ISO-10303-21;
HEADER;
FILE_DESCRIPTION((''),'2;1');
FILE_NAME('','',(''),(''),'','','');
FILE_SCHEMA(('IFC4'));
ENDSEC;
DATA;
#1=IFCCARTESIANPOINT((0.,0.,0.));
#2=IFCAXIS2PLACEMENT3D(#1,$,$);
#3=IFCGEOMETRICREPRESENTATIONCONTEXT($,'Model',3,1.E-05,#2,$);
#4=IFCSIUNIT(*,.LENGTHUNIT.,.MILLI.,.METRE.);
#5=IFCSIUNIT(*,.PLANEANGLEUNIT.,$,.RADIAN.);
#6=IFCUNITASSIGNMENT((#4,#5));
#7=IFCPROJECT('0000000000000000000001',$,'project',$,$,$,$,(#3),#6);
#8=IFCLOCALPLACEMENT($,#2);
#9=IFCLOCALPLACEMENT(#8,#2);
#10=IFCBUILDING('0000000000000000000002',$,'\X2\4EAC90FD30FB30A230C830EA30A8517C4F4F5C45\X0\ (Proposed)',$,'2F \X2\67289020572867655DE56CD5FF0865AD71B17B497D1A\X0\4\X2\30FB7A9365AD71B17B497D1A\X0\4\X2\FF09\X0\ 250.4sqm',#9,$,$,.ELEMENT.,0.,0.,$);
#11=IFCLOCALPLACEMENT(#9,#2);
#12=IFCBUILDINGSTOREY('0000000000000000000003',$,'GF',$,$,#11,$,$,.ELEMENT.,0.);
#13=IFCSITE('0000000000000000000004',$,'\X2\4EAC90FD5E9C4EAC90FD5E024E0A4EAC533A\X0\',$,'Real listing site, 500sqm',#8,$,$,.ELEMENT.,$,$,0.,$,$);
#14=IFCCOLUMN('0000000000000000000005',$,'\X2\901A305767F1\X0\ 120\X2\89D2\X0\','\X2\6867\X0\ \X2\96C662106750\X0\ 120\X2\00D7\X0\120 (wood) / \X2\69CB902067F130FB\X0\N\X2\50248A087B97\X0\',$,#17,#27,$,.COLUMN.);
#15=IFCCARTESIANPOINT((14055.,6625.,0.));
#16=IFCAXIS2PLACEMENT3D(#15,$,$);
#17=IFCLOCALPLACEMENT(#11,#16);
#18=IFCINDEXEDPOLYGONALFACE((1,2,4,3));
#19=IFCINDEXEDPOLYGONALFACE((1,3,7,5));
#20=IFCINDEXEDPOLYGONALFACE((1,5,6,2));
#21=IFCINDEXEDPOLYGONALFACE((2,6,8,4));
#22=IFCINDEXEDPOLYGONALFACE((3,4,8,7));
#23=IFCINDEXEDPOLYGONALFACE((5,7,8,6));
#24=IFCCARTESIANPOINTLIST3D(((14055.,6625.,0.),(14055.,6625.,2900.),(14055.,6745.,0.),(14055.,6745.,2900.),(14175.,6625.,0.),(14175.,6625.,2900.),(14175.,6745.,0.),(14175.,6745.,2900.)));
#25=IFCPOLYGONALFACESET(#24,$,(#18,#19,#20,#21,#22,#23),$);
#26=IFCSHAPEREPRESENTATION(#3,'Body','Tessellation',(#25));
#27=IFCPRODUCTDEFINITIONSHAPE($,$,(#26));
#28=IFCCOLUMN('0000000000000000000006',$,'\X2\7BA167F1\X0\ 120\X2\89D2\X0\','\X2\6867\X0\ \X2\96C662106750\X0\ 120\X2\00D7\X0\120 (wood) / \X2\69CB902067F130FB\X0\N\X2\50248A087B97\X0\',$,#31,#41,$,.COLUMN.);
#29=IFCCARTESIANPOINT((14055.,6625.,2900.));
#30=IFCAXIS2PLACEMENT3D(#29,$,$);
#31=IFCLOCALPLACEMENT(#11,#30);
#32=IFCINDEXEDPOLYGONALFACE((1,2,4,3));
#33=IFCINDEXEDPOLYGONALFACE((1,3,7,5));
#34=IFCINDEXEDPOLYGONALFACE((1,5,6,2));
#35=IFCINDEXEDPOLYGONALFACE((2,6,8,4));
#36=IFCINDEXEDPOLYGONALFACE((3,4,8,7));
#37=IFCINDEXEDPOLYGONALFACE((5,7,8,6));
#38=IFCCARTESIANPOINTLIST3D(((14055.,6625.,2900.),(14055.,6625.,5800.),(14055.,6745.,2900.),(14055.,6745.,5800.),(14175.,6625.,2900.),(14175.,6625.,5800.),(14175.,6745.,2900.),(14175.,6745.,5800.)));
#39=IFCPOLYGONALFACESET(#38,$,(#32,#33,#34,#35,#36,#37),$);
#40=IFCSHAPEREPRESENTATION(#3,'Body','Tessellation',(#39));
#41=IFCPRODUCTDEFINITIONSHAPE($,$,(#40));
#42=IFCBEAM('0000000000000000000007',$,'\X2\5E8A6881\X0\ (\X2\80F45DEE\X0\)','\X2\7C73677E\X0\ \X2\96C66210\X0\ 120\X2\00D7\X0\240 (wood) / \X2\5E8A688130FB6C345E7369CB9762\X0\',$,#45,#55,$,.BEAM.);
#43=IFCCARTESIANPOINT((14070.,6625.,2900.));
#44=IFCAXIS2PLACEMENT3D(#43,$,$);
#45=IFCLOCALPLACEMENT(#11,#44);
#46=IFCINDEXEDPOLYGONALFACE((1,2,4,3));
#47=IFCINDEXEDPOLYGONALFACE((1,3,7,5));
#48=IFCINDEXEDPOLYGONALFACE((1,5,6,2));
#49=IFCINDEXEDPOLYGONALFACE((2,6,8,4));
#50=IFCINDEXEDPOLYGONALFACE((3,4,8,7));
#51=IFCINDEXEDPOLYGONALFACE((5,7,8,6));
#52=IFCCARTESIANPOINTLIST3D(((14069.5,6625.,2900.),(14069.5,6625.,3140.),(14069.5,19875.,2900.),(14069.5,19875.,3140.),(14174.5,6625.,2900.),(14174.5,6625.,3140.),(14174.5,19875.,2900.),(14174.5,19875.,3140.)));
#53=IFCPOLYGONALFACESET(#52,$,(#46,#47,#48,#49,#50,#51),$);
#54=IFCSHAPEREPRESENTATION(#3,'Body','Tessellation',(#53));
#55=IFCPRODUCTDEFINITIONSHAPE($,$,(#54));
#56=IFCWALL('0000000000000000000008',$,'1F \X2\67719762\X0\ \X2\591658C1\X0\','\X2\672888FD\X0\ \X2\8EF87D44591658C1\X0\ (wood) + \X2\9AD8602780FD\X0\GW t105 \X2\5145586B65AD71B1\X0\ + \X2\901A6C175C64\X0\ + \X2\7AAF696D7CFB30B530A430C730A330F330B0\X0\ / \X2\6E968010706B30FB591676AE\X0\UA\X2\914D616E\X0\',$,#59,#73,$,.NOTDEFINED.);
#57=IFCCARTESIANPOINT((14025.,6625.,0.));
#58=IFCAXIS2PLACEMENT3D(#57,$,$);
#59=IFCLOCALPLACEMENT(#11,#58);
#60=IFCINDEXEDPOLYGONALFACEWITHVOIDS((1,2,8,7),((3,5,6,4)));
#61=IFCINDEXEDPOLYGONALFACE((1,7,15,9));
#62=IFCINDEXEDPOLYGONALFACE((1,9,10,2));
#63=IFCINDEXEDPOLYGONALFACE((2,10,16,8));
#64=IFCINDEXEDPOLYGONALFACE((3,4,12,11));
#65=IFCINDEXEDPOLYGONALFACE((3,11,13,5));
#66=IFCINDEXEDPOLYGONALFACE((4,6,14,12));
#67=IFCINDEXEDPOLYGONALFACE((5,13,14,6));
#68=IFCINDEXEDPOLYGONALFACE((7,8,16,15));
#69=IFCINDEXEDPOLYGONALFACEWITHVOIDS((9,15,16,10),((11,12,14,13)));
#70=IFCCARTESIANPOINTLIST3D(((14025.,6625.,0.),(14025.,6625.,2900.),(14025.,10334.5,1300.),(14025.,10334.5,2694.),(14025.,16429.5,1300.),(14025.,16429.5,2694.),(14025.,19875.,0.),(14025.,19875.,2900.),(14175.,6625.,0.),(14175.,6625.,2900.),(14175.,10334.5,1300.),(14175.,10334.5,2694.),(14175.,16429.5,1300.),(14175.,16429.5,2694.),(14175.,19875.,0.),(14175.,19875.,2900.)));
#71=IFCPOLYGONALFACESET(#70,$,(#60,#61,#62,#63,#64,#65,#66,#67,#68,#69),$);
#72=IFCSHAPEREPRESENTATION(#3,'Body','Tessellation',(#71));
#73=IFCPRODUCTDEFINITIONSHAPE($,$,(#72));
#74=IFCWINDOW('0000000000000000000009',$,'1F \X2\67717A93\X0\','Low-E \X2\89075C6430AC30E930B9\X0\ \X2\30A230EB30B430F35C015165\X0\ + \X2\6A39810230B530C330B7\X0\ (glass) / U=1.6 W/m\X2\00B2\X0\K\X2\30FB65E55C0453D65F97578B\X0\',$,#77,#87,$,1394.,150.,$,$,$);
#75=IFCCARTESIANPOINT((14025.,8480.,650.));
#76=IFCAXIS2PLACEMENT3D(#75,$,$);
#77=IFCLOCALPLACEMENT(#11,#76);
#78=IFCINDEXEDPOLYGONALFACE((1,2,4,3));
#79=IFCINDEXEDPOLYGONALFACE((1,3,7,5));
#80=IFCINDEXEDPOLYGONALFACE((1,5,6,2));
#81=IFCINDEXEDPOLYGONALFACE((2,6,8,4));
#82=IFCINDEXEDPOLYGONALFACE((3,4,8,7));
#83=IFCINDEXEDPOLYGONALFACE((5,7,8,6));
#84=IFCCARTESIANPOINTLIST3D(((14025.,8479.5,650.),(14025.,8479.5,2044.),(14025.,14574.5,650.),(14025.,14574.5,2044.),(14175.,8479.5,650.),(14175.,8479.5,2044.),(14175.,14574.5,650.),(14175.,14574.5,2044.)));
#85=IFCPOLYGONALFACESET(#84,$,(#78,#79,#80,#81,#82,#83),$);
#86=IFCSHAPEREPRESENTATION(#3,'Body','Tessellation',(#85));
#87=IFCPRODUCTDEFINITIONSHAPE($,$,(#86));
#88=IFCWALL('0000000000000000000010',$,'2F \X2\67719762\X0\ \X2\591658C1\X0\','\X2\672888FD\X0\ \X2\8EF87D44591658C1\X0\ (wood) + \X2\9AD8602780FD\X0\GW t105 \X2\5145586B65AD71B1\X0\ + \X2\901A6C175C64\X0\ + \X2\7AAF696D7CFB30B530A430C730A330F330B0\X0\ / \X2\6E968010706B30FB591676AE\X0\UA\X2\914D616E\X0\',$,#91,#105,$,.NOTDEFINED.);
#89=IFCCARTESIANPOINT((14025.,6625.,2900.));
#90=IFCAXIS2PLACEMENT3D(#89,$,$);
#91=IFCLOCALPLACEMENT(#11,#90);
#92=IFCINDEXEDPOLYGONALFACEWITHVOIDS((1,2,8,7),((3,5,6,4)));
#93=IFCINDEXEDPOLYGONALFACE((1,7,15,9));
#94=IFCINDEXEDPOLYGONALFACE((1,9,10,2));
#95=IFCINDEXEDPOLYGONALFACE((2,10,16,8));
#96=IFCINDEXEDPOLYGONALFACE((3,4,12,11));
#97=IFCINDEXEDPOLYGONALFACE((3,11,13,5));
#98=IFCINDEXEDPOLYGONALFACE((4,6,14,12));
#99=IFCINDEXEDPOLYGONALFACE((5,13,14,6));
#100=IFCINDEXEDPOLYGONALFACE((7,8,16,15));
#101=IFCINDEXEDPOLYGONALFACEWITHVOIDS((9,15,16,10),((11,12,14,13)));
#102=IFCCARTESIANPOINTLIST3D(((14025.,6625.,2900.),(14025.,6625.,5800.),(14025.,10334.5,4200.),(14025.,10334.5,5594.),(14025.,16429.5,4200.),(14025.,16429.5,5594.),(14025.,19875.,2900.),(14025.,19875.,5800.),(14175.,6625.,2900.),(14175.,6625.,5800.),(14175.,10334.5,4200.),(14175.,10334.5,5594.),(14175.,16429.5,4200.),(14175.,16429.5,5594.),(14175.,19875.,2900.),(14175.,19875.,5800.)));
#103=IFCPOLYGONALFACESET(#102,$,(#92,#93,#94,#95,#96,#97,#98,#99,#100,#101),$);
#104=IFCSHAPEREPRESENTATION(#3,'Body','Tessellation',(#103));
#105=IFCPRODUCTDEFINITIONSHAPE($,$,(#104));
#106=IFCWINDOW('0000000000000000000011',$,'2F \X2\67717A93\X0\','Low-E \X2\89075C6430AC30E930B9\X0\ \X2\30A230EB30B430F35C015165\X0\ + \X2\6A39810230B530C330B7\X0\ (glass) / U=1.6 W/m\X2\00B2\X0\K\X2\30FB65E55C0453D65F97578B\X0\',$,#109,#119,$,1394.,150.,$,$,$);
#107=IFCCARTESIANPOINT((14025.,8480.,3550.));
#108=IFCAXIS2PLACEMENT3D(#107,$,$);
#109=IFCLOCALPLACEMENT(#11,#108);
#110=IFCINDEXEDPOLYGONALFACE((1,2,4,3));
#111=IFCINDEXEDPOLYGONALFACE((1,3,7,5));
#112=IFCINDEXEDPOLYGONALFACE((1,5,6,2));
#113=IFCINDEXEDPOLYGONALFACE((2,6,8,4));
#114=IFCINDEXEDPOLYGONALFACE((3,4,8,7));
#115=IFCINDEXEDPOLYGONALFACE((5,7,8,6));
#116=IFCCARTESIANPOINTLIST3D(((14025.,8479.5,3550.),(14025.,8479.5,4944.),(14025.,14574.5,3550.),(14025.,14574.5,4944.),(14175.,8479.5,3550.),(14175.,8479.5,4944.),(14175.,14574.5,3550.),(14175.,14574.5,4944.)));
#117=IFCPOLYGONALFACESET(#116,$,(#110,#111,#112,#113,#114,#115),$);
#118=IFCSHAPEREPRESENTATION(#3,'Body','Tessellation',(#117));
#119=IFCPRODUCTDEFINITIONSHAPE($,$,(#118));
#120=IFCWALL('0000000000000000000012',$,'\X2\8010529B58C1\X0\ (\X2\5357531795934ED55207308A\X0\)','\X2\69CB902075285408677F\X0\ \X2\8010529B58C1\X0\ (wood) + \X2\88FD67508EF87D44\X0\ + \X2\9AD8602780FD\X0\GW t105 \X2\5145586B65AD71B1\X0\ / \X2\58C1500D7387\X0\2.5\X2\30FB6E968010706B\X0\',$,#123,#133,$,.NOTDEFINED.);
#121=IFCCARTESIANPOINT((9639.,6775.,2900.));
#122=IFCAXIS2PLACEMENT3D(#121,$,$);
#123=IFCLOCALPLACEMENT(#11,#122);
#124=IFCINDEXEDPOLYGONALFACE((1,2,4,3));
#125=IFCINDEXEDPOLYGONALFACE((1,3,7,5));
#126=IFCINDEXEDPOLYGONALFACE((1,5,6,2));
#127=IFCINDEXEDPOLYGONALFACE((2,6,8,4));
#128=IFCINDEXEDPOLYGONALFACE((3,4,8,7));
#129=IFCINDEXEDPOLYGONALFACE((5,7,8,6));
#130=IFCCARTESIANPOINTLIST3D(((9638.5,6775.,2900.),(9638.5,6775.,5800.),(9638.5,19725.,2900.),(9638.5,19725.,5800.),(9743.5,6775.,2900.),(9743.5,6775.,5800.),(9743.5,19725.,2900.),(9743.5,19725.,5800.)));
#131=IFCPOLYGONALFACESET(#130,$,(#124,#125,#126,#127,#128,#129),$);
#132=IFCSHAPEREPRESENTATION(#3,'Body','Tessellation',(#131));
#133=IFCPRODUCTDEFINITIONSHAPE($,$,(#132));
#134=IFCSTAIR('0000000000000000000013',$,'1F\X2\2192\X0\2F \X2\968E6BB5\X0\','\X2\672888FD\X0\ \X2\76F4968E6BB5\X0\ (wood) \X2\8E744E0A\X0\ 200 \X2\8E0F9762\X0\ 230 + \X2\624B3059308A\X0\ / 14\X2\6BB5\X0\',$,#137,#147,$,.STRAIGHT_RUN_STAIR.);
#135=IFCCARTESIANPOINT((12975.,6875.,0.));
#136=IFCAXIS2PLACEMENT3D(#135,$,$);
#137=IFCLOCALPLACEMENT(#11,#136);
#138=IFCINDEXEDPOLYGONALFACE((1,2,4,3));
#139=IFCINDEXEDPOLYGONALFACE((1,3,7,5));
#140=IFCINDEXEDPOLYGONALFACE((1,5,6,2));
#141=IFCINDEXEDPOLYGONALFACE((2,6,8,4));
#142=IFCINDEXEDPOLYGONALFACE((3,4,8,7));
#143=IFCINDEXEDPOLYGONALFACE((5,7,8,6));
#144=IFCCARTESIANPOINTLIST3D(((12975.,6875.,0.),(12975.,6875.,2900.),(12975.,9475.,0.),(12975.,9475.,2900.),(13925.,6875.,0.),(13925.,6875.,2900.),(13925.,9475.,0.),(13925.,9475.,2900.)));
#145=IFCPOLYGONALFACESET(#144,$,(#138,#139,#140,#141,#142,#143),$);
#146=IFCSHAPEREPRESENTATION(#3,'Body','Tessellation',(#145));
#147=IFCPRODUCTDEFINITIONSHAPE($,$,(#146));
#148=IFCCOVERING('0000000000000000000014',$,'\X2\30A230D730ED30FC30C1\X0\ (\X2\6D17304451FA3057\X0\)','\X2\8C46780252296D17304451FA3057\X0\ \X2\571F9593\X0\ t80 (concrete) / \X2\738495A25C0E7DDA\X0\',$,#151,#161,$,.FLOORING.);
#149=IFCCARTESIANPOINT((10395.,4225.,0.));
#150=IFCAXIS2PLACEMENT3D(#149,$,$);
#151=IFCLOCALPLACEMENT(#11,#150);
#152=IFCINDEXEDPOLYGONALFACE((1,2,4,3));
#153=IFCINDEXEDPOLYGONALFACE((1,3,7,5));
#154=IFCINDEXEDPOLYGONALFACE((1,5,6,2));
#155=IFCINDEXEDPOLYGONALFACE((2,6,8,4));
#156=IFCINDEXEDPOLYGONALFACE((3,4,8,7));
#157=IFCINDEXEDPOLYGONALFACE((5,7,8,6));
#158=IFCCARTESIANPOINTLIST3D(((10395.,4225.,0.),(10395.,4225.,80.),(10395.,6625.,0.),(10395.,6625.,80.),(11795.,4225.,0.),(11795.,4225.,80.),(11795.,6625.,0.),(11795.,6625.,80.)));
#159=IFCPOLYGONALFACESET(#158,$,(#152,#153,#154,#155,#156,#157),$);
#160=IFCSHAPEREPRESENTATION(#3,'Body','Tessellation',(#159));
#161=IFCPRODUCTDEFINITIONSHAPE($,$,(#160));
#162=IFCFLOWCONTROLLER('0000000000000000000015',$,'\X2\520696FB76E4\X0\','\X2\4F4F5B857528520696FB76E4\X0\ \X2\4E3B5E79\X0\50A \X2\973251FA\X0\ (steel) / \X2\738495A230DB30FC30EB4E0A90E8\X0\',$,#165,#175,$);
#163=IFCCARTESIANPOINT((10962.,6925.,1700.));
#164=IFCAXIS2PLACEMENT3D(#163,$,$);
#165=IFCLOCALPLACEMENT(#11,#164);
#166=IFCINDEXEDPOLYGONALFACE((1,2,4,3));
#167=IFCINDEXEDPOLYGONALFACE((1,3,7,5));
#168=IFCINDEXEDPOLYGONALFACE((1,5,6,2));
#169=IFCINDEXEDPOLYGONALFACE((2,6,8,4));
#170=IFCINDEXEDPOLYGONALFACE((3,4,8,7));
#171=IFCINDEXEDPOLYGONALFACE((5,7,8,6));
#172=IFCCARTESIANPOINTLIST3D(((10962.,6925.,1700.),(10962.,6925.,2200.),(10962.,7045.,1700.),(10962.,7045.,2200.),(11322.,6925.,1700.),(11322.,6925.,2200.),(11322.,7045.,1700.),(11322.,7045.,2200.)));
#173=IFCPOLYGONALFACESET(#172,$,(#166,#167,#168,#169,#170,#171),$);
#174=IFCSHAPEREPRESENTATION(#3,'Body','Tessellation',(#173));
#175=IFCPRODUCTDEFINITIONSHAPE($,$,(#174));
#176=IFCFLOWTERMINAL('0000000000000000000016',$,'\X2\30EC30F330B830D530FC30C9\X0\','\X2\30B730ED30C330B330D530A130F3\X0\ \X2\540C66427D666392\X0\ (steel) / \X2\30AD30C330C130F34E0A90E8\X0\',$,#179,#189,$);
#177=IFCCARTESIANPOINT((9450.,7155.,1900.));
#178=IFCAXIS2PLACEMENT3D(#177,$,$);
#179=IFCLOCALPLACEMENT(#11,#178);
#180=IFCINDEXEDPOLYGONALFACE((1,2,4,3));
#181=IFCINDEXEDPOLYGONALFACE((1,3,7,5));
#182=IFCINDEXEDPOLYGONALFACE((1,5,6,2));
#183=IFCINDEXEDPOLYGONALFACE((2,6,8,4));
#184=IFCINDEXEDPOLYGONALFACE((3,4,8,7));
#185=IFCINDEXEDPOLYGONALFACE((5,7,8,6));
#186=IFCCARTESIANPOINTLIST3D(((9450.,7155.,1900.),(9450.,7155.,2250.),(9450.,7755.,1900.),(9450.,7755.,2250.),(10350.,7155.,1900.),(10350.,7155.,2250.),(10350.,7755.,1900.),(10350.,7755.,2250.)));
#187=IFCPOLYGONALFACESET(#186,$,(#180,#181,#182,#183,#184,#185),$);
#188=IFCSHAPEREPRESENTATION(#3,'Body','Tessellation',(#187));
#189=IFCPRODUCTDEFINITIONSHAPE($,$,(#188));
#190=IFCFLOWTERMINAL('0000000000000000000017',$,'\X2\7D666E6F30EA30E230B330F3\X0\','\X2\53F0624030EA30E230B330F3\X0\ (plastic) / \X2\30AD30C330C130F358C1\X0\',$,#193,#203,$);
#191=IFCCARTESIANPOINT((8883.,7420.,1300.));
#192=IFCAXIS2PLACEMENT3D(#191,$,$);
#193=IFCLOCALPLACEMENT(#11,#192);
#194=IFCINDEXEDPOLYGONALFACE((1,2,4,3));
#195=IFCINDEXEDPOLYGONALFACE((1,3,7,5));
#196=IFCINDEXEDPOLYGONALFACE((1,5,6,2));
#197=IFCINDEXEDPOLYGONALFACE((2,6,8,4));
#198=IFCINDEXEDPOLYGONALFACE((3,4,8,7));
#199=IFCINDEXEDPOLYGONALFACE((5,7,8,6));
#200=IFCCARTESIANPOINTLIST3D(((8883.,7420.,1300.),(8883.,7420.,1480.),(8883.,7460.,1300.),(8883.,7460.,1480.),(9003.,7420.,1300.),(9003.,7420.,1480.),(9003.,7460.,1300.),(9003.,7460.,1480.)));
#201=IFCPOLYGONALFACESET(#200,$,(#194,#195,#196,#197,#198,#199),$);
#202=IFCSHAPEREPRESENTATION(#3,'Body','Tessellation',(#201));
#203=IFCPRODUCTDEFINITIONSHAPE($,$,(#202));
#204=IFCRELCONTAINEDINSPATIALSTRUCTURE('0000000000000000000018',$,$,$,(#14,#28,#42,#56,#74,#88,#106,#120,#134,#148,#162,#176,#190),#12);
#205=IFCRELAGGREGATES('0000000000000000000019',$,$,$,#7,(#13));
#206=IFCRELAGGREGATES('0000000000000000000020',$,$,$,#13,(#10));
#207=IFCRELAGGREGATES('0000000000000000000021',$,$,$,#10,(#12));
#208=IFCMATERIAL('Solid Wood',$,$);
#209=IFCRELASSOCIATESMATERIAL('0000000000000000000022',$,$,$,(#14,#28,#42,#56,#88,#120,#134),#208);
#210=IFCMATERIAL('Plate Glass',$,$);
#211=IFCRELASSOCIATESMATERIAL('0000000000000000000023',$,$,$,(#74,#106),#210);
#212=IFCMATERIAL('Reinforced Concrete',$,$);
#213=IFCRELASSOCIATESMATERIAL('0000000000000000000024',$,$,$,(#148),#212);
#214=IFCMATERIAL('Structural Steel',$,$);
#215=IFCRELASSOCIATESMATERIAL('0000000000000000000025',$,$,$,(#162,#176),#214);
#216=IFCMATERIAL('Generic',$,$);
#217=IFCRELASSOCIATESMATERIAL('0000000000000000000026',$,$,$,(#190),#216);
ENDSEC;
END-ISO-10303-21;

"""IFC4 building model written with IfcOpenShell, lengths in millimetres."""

from ifc_helpers import new_model, si_unit, frame, frame_2d, origin, place, context, project, spatial, rectangle, extrude, material, element, fill, save


model = new_model("IFC4")

# Units and contexts
model_context = context("Model", 3, precision=1e-05, world=origin())
ifc_project = project(units=[si_unit("LENGTHUNIT", "METRE", prefix="MILLI"), si_unit("PLANEANGLEUNIT", "RADIAN")], contexts=[model_context])

# Site, building, storey
site_placement = place(None, origin())
site = spatial("IfcSite", under=ifc_project, at=site_placement, Name="京都府京都市上京区", ObjectType="Real listing site, 500sqm", CompositionType="ELEMENT", RefElevation=0.0)
building_placement = place(site_placement, origin())
building = spatial("IfcBuilding", under=site, at=building_placement, Name="京都・アトリエ兼住居 (Proposed)", ObjectType="2F 木造在来工法（断熱等級4・窓断熱等級4） 250.4sqm", CompositionType="ELEMENT", ElevationOfRefHeight=0.0, ElevationOfTerrain=0.0)
storey_placement = place(building_placement, origin())
storey = spatial("IfcBuildingStorey", under=building, at=storey_placement, Name="GF", CompositionType="ELEMENT", Elevation=0.0)

# Columns
ifc_material_1 = material(Name="Solid Wood")
column_1_placement = place(storey_placement, frame((14055.0, 6625.0, 0.0)))
element("IfcColumn", 1, at=column_1_placement, inside=storey, material=ifc_material_1, Name="通し柱 120角", Description="桧 集成材 120×120 (wood) / 構造柱・N値計算", PredefinedType="COLUMN", context=model_context, shape_type="SweptSolid", body=[
    extrude(rectangle(XDim=120.0, YDim=120.0, at=frame_2d((60.0, 60.0))), frame((14055.0, 6625.0, 0.0)), (0.0, 0.0, 1.0), 2900.0),
])
column_2_placement = place(storey_placement, frame((14055.0, 6625.0, 2900.0)))
element("IfcColumn", 2, at=column_2_placement, inside=storey, material=ifc_material_1, Name="管柱 120角", Description="桧 集成材 120×120 (wood) / 構造柱・N値計算", PredefinedType="COLUMN", context=model_context, shape_type="SweptSolid", body=[
    extrude(rectangle(XDim=120.0, YDim=120.0, at=frame_2d((60.0, 60.0))), frame((14055.0, 6625.0, 2900.0)), (0.0, 0.0, 1.0), 2900.0),
])

# Beam
beam_1_placement = place(storey_placement, frame((14070.0, 6625.0, 2900.0)))
element("IfcBeam", 3, at=beam_1_placement, inside=storey, material=ifc_material_1, Name="床梁 (胴差)", Description="米松 集成 120×240 (wood) / 床梁・水平構面", PredefinedType="BEAM", context=model_context, shape_type="SweptSolid", body=[
    extrude(rectangle(XDim=105.0, YDim=13250.0, at=frame_2d((52.0, 6625.0))), frame((14070.0, 6625.0, 2900.0)), (0.0, 0.0, 1.0), 240.0),
])

# Wall, opening, window
wall_1_placement = place(storey_placement, frame((14025.0, 6625.0, 0.0)))
wall_1 = element("IfcWall", 4, at=wall_1_placement, inside=storey, material=ifc_material_1, Name="1F 東面 外壁", Description="木製 軸組外壁 (wood) + 高性能GW t105 充填断熱 + 通気層 + 窯業系サイディング / 準耐火・外皮UA配慮", PredefinedType="NOTDEFINED", context=model_context, shape_type="SweptSolid", body=[
    extrude(rectangle(XDim=150.0, YDim=13250.0, at=frame_2d((75.0, 6625.0))), frame((14025.0, 6625.0, 0.0)), (0.0, 0.0, 1.0), 2900.0),
])
opening_1_placement = place(storey_placement, frame((14025.0, 8480.0, 650.0)))
opening_1 = element("IfcOpeningElement", 5, at=opening_1_placement, cuts=wall_1, PredefinedType="NOTDEFINED", context=model_context, shape_type="SweptSolid", body=[
    extrude(rectangle(XDim=150.0, YDim=6095.0, at=frame_2d((75.0, 3047.0))), frame((14025.0, 8480.0, 650.0)), (0.0, 0.0, 1.0), 1394.0),
])
ifc_material_2 = material(Name="Plate Glass")
window_1_placement = place(storey_placement, frame((14025.0, 8480.0, 650.0)))
window_1 = element("IfcWindow", 6, at=window_1_placement, inside=storey, material=ifc_material_2, Name="1F 東窓", Description="Low-E 複層ガラス アルゴン封入 + 樹脂サッシ (glass) / U=1.6 W/m²K・日射取得型", OverallHeight=1394.0, OverallWidth=150.0, context=model_context, shape_type="SweptSolid", body=[
    extrude(rectangle(XDim=150.0, YDim=6095.0, at=frame_2d((75.0, 3047.0))), frame((14025.0, 8480.0, 650.0)), (0.0, 0.0, 1.0), 1394.0),
])
fill(opening_1, window_1)

# Wall, opening, window
wall_2_placement = place(storey_placement, frame((14025.0, 6625.0, 2900.0)))
wall_2 = element("IfcWall", 7, at=wall_2_placement, inside=storey, material=ifc_material_1, Name="2F 東面 外壁", Description="木製 軸組外壁 (wood) + 高性能GW t105 充填断熱 + 通気層 + 窯業系サイディング / 準耐火・外皮UA配慮", PredefinedType="NOTDEFINED", context=model_context, shape_type="SweptSolid", body=[
    extrude(rectangle(XDim=150.0, YDim=13250.0, at=frame_2d((75.0, 6625.0))), frame((14025.0, 6625.0, 2900.0)), (0.0, 0.0, 1.0), 2900.0),
])
opening_2_placement = place(storey_placement, frame((14025.0, 8480.0, 3550.0)))
opening_2 = element("IfcOpeningElement", 8, at=opening_2_placement, cuts=wall_2, PredefinedType="NOTDEFINED", context=model_context, shape_type="SweptSolid", body=[
    extrude(rectangle(XDim=150.0, YDim=6095.0, at=frame_2d((75.0, 3047.0))), frame((14025.0, 8480.0, 3550.0)), (0.0, 0.0, 1.0), 1394.0),
])
window_2_placement = place(storey_placement, frame((14025.0, 8480.0, 3550.0)))
window_2 = element("IfcWindow", 9, at=window_2_placement, inside=storey, material=ifc_material_2, Name="2F 東窓", Description="Low-E 複層ガラス アルゴン封入 + 樹脂サッシ (glass) / U=1.6 W/m²K・日射取得型", OverallHeight=1394.0, OverallWidth=150.0, context=model_context, shape_type="SweptSolid", body=[
    extrude(rectangle(XDim=150.0, YDim=6095.0, at=frame_2d((75.0, 3047.0))), frame((14025.0, 8480.0, 3550.0)), (0.0, 0.0, 1.0), 1394.0),
])
fill(opening_2, window_2)

# Wall
wall_3_placement = place(storey_placement, frame((9639.0, 6775.0, 2900.0)))
element("IfcWall", 10, at=wall_3_placement, inside=storey, material=ifc_material_1, Name="耐力壁 (南北間仕切り)", Description="構造用合板 耐力壁 (wood) + 製材軸組 + 高性能GW t105 充填断熱 / 壁倍率2.5・準耐火", PredefinedType="NOTDEFINED", context=model_context, shape_type="SweptSolid", body=[
    extrude(rectangle(XDim=105.0, YDim=12950.0, at=frame_2d((52.0, 6475.0))), frame((9639.0, 6775.0, 2900.0)), (0.0, 0.0, 1.0), 2900.0),
])

# Stair
stair_placement = place(storey_placement, frame((12975.0, 6875.0, 0.0)))
element("IfcStair", 11, at=stair_placement, inside=storey, material=ifc_material_1, Name="1F→2F 階段", Description="木製 直階段 (wood) 蹴上 200 踏面 230 + 手すり / 14段", PredefinedType="STRAIGHT_RUN_STAIR", context=model_context, shape_type="SweptSolid", body=[
    extrude(rectangle(XDim=950.0, YDim=2600.0, at=frame_2d((475.0, 1300.0))), frame((12975.0, 6875.0, 0.0)), (0.0, 0.0, 1.0), 2900.0),
])

# Covering
ifc_material_3 = material(Name="Reinforced Concrete")
covering_placement = place(storey_placement, frame((10395.0, 4225.0, 0.0)))
element("IfcCovering", 12, at=covering_placement, inside=storey, material=ifc_material_3, Name="アプローチ (洗い出し)", Description="豆砂利洗い出し 土間 t80 (concrete) / 玄関導線", PredefinedType="FLOORING", context=model_context, shape_type="SweptSolid", body=[
    extrude(rectangle(XDim=1400.0, YDim=2400.0, at=frame_2d((700.0, 1200.0))), frame((10395.0, 4225.0, 0.0)), (0.0, 0.0, 1.0), 80.0),
])

# Flow controller
ifc_material_4 = material(Name="Structural Steel")
flow_controller_placement = place(storey_placement, frame((10962.0, 6925.0, 1700.0)))
element("IfcFlowController", 13, at=flow_controller_placement, inside=storey, material=ifc_material_4, Name="分電盤", Description="住宅用分電盤 主幹50A 露出 (steel) / 玄関ホール上部", context=model_context, shape_type="SweptSolid", body=[
    extrude(rectangle(XDim=360.0, YDim=120.0, at=frame_2d((180.0, 60.0))), frame((10962.0, 6925.0, 1700.0)), (0.0, 0.0, 1.0), 500.0),
])

# Flow terminals
flow_terminal_1_placement = place(storey_placement, frame((9450.0, 7155.0, 1900.0)))
element("IfcFlowTerminal", 14, at=flow_terminal_1_placement, inside=storey, material=ifc_material_4, Name="レンジフード", Description="シロッコファン 同時給排 (steel) / キッチン上部", context=model_context, shape_type="SweptSolid", body=[
    extrude(rectangle(XDim=900.0, YDim=600.0, at=frame_2d((450.0, 300.0))), frame((9450.0, 7155.0, 1900.0)), (0.0, 0.0, 1.0), 350.0),
])
ifc_material_5 = material(Name="Generic")
flow_terminal_2_placement = place(storey_placement, frame((8883.0, 7420.0, 1300.0)))
element("IfcFlowTerminal", 15, at=flow_terminal_2_placement, inside=storey, material=ifc_material_5, Name="給湯リモコン", Description="台所リモコン (plastic) / キッチン壁", context=model_context, shape_type="SweptSolid", body=[
    extrude(rectangle(XDim=120.0, YDim=40.0, at=frame_2d((60.0, 20.0))), frame((8883.0, 7420.0, 1300.0)), (0.0, 0.0, 1.0), 180.0),
])

save(model, "model.ifc")
